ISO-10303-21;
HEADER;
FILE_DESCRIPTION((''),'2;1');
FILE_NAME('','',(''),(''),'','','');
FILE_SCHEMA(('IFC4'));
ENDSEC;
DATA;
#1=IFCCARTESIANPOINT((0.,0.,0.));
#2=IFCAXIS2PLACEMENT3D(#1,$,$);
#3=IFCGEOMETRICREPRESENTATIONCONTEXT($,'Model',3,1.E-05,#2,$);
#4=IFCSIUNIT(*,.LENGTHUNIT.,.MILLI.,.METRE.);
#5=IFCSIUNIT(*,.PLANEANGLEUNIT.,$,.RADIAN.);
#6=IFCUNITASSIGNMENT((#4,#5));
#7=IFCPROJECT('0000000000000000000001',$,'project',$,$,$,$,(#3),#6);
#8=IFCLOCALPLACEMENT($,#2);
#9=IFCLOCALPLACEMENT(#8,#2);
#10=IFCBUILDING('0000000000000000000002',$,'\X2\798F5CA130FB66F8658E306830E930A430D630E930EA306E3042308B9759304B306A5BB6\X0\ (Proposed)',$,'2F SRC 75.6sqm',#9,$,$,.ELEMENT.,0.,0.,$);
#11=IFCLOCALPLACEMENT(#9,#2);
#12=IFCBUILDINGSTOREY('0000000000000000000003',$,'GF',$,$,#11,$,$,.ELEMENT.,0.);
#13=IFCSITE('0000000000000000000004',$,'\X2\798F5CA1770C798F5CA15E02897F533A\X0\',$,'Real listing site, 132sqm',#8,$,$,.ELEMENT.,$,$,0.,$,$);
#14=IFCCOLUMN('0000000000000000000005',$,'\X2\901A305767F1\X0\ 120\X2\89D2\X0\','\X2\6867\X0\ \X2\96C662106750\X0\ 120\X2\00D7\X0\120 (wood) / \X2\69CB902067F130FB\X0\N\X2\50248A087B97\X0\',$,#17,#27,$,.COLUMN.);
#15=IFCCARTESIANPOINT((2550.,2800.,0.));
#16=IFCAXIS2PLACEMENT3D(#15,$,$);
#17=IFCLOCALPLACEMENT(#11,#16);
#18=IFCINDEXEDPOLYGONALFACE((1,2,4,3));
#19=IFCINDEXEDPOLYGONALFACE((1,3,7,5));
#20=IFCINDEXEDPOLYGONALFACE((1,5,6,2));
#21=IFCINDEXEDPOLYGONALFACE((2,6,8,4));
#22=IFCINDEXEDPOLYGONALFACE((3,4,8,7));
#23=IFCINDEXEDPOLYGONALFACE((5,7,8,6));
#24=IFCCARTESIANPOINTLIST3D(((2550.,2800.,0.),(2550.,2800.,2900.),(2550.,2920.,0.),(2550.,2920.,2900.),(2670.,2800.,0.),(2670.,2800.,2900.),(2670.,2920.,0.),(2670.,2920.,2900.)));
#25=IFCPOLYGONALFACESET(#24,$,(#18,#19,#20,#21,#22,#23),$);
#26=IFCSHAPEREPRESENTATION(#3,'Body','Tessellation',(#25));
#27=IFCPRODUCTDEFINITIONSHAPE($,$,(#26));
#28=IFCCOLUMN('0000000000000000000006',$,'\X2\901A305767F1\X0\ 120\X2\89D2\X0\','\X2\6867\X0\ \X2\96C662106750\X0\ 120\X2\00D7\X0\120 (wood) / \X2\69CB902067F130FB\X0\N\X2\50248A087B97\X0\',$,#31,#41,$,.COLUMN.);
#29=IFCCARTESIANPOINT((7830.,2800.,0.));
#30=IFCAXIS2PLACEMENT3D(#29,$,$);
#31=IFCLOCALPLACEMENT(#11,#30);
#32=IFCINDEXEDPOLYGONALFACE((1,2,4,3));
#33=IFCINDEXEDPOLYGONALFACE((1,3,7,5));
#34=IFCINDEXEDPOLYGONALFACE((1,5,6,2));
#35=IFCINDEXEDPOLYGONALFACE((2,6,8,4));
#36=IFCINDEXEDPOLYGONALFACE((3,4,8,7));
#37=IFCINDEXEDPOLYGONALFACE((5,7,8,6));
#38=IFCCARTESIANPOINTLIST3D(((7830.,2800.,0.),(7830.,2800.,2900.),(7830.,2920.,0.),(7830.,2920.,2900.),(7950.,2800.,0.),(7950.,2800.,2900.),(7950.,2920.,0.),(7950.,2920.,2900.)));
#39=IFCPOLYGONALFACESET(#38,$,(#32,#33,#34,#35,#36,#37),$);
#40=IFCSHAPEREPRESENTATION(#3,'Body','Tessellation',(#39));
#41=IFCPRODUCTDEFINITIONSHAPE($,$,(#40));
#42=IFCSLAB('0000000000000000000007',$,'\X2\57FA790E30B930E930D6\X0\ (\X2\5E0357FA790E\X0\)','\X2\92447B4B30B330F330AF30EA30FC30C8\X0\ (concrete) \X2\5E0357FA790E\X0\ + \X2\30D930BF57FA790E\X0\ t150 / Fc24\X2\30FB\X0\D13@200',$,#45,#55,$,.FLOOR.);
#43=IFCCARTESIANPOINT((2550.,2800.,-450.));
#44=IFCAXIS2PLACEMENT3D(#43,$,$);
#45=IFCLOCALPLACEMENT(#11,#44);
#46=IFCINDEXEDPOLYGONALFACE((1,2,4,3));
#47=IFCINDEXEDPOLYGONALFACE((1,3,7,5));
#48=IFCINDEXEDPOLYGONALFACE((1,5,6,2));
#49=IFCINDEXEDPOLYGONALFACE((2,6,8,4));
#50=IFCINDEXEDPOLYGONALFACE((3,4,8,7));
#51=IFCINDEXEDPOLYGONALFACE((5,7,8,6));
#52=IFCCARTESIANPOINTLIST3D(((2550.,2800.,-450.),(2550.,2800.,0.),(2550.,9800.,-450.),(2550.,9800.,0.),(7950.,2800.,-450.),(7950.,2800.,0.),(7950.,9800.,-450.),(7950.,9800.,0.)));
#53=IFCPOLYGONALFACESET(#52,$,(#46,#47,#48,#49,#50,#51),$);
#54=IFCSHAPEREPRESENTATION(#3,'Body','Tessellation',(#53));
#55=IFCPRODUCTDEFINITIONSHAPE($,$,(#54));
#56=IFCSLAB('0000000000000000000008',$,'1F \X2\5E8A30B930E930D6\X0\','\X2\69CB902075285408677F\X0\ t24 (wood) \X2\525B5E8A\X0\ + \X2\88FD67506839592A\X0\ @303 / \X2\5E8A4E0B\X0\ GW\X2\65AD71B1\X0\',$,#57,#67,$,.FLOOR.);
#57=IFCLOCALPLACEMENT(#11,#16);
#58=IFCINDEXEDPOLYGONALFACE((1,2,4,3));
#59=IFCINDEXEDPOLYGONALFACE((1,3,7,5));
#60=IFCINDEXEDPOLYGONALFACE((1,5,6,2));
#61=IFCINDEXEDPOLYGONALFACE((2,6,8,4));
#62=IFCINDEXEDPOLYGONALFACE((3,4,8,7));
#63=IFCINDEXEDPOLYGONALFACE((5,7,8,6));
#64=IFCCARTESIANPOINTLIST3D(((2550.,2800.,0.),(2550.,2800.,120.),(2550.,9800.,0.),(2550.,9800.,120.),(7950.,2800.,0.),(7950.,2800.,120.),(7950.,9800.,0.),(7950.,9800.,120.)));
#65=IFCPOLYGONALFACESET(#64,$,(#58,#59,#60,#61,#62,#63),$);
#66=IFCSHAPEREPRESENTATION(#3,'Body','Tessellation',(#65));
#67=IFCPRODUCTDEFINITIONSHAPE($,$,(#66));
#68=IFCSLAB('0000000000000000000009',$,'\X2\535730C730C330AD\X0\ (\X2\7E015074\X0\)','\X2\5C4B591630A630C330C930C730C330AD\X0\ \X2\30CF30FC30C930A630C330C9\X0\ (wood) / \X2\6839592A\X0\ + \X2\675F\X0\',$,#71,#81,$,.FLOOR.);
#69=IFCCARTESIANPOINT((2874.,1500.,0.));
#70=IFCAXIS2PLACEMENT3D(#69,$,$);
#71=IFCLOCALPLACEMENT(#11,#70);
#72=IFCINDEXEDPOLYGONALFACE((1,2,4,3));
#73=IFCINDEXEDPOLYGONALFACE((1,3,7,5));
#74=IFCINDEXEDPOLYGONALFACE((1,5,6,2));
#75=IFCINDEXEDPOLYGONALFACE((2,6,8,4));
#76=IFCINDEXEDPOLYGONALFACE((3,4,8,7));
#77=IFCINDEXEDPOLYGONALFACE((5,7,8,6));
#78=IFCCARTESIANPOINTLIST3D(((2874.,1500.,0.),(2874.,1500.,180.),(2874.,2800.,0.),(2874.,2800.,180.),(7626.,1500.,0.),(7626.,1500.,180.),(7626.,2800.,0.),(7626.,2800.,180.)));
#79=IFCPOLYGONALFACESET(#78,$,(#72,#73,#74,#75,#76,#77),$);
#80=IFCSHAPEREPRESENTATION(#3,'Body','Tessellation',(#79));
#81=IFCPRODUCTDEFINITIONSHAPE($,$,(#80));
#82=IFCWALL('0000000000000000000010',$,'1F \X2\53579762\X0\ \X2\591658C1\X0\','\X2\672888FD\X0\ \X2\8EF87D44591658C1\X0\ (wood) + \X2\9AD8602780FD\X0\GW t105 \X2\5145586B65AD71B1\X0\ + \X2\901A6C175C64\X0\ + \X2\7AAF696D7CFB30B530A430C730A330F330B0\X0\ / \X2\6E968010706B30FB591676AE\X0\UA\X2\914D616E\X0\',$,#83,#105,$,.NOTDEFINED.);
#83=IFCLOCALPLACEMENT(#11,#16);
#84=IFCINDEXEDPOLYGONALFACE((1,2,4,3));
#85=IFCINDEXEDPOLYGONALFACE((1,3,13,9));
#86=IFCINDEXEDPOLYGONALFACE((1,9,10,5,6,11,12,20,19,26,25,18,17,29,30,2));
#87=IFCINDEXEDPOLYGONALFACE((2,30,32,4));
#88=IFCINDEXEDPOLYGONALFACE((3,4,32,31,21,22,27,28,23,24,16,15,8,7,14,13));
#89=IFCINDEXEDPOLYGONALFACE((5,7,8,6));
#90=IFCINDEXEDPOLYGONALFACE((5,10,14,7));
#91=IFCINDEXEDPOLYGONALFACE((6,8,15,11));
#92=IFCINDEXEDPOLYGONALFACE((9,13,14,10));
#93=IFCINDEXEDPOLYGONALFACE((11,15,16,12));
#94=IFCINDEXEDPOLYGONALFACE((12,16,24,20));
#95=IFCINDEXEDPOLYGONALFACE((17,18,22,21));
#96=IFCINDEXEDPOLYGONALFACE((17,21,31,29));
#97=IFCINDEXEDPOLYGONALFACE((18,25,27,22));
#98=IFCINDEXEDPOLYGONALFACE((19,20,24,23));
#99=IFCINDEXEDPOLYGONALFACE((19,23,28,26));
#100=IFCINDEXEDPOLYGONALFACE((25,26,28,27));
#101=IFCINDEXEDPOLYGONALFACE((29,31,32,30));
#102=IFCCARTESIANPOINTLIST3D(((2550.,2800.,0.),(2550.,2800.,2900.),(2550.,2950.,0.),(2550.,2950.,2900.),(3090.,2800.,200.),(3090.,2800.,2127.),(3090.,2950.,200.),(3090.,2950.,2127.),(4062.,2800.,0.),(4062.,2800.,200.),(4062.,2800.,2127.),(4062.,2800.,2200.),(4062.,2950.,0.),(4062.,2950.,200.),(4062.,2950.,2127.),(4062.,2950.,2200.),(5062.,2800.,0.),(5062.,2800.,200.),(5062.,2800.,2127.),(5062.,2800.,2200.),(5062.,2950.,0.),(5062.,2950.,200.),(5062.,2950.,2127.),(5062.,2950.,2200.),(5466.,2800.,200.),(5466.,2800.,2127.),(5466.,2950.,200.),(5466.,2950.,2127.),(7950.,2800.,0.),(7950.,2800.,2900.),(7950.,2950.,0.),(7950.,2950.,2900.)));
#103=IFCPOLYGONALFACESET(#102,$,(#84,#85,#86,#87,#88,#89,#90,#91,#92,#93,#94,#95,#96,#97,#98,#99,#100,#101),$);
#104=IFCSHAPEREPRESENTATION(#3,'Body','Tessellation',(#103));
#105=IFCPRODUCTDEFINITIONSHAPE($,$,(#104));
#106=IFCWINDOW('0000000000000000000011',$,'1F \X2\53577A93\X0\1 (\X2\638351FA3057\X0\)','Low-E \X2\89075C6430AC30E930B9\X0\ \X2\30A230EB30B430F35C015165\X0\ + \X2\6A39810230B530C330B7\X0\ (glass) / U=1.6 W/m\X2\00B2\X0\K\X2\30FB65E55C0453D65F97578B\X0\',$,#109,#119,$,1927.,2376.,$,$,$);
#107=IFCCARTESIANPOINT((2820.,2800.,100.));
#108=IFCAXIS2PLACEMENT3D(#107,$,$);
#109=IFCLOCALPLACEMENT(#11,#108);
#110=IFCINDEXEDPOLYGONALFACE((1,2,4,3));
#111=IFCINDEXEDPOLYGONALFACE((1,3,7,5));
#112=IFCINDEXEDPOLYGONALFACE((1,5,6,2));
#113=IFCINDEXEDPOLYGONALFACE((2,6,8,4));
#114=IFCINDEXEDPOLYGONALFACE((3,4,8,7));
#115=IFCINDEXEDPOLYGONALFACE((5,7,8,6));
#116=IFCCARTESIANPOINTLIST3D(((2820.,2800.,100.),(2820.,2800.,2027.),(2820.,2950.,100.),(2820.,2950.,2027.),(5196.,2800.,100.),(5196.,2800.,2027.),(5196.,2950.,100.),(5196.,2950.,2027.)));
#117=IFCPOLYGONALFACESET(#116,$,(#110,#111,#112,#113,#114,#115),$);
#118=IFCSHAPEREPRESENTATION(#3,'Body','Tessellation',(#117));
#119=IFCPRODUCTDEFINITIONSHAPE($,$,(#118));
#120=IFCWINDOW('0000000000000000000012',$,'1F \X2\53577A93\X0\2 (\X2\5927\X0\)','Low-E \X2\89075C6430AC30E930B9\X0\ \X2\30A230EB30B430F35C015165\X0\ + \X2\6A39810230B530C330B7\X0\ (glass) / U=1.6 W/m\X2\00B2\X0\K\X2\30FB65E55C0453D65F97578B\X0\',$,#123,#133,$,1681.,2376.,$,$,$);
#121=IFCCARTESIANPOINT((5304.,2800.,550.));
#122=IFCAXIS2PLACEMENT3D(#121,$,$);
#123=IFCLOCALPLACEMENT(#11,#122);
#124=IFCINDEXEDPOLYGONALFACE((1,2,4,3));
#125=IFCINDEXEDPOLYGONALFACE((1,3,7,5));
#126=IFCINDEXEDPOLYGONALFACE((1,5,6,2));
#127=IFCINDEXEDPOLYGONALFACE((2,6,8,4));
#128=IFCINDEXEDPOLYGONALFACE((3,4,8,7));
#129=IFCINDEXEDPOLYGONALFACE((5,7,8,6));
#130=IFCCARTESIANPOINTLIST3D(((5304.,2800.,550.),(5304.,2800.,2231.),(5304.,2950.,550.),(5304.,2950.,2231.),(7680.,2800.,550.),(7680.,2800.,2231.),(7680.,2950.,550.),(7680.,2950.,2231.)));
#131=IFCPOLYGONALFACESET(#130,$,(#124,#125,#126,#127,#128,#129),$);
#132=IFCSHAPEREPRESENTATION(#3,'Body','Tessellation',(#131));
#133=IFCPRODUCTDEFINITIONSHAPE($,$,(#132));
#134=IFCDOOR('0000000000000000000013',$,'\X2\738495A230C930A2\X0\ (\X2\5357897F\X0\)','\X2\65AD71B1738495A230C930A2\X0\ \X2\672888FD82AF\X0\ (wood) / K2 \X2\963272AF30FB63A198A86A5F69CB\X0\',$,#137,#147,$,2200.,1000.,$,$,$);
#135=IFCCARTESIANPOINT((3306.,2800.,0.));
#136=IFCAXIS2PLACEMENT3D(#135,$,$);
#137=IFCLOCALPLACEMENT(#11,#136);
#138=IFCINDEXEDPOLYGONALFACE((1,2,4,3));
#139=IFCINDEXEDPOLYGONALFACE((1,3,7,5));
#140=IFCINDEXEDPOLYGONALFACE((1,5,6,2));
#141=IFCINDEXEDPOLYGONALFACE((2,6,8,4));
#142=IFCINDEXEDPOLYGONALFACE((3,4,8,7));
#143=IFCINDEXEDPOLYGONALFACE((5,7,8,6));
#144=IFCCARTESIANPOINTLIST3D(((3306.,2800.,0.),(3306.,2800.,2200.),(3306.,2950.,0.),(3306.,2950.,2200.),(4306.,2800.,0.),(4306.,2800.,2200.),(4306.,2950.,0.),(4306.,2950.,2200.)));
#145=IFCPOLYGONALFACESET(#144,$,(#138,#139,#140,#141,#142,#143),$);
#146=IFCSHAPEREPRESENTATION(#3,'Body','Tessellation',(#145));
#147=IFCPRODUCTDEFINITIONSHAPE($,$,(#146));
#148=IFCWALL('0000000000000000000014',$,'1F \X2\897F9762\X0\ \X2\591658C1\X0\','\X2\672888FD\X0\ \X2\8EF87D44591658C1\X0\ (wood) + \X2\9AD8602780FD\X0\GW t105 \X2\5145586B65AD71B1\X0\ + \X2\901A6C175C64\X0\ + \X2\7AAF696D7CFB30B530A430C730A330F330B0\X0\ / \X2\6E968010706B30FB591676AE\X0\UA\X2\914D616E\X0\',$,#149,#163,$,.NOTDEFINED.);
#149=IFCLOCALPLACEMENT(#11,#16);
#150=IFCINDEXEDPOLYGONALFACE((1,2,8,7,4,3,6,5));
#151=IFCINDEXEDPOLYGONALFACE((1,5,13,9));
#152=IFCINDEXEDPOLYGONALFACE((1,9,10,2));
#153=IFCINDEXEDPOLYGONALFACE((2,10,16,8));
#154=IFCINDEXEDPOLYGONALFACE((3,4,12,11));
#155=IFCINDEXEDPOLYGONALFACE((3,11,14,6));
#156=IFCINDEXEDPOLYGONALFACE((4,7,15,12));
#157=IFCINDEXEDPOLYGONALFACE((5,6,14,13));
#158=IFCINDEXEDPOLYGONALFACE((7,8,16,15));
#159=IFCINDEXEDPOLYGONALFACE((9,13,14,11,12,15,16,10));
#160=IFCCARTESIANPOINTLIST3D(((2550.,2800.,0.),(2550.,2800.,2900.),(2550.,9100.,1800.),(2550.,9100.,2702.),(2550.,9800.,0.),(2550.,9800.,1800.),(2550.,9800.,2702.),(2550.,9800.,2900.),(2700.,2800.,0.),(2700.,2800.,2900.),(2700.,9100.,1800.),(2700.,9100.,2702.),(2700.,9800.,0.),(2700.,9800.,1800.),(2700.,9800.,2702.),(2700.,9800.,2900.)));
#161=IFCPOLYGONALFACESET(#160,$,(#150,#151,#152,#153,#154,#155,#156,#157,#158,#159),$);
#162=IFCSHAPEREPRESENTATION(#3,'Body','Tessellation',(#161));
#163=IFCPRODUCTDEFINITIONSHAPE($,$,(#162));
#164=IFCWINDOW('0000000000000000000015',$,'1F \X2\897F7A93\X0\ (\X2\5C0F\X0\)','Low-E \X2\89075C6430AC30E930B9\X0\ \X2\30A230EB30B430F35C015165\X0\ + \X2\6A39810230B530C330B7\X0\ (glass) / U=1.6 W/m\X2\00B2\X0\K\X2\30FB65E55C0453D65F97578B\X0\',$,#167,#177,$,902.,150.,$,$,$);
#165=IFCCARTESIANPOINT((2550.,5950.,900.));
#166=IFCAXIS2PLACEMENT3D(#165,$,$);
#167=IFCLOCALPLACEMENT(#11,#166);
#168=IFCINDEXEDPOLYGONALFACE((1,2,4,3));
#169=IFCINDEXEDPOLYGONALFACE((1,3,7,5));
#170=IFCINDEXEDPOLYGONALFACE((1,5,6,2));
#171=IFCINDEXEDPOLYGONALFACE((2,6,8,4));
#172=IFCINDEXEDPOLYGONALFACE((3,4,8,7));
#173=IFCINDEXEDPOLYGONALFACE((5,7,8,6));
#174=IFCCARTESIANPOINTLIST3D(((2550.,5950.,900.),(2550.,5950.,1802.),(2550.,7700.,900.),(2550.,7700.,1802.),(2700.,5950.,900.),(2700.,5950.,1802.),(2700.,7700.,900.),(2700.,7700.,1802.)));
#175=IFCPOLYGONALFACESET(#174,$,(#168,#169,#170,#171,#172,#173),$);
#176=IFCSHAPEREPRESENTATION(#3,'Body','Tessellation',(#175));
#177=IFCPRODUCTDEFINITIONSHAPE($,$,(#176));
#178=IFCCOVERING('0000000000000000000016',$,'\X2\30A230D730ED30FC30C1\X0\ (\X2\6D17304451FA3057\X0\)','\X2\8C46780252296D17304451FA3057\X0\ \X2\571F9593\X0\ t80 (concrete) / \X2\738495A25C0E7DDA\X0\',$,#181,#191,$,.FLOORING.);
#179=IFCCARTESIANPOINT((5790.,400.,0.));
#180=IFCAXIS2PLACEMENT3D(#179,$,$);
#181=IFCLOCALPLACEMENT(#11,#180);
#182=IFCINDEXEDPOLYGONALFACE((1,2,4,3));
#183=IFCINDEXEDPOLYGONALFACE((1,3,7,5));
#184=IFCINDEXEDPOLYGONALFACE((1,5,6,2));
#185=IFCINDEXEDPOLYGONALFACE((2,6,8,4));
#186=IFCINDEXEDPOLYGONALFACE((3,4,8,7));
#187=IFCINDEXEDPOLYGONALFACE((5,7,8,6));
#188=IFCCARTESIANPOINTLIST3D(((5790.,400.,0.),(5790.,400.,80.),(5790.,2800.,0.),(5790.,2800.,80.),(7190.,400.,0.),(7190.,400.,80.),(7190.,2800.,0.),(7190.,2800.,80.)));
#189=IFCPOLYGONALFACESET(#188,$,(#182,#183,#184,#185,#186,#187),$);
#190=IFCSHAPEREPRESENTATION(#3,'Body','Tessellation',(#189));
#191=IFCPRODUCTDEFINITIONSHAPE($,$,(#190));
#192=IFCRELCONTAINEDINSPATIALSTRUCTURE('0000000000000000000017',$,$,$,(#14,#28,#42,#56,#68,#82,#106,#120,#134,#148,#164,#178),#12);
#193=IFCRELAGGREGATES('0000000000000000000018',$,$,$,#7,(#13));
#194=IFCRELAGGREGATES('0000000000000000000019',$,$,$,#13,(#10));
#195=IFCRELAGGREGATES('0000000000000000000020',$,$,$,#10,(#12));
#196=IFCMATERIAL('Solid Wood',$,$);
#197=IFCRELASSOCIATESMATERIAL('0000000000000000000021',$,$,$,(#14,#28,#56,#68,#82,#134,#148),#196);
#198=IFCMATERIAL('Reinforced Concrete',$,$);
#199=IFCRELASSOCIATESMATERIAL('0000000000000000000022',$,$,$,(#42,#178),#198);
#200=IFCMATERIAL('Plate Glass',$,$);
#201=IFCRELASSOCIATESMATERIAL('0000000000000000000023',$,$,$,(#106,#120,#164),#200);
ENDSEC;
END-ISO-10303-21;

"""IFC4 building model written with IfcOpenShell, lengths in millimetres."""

from ifc_helpers import new_model, si_unit, frame, frame_2d, origin, place, context, project, spatial, rectangle, extrude, material, element, fill, save


model = new_model("IFC4")

# Units and contexts
model_context = context("Model", 3, precision=1e-05, world=origin())
ifc_project = project(units=[si_unit("LENGTHUNIT", "METRE", prefix="MILLI"), si_unit("PLANEANGLEUNIT", "RADIAN")], contexts=[model_context])

# Site, building, storey
site_placement = place(None, origin())
site = spatial("IfcSite", under=ifc_project, at=site_placement, Name="福岡県福岡市西区", ObjectType="Real listing site, 132sqm", CompositionType="ELEMENT", RefElevation=0.0)
building_placement = place(site_placement, origin())
building = spatial("IfcBuilding", under=site, at=building_placement, Name="福岡・書斎とライブラリのある静かな家 (Proposed)", ObjectType="2F SRC 75.6sqm", CompositionType="ELEMENT", ElevationOfRefHeight=0.0, ElevationOfTerrain=0.0)
storey_placement = place(building_placement, origin())
storey = spatial("IfcBuildingStorey", under=building, at=storey_placement, Name="GF", CompositionType="ELEMENT", Elevation=0.0)

# Columns
ifc_material_1 = material(Name="Solid Wood")
column_1_placement = place(storey_placement, frame((2550.0, 2800.0, 0.0)))
element("IfcColumn", 1, at=column_1_placement, inside=storey, material=ifc_material_1, Name="通し柱 120角", Description="桧 集成材 120×120 (wood) / 構造柱・N値計算", PredefinedType="COLUMN", context=model_context, shape_type="SweptSolid", body=[
    extrude(rectangle(XDim=120.0, YDim=120.0, at=frame_2d((60.0, 60.0))), frame((2550.0, 2800.0, 0.0)), (0.0, 0.0, 1.0), 2900.0),
])
column_2_placement = place(storey_placement, frame((7830.0, 2800.0, 0.0)))
element("IfcColumn", 2, at=column_2_placement, inside=storey, material=ifc_material_1, Name="通し柱 120角", Description="桧 集成材 120×120 (wood) / 構造柱・N値計算", PredefinedType="COLUMN", context=model_context, shape_type="SweptSolid", body=[
    extrude(rectangle(XDim=120.0, YDim=120.0, at=frame_2d((60.0, 60.0))), frame((7830.0, 2800.0, 0.0)), (0.0, 0.0, 1.0), 2900.0),
])

# Slabs
ifc_material_2 = material(Name="Reinforced Concrete")
slab_1_placement = place(storey_placement, frame((2550.0, 2800.0, -450.0)))
element("IfcSlab", 3, at=slab_1_placement, inside=storey, material=ifc_material_2, Name="基礎スラブ (布基礎)", Description="鉄筋コンクリート (concrete) 布基礎 + ベタ基礎 t150 / Fc24・D13@200", PredefinedType="FLOOR", context=model_context, shape_type="SweptSolid", body=[
    extrude(rectangle(XDim=5400.0, YDim=7000.0, at=frame_2d((2700.0, 3500.0))), frame((2550.0, 2800.0, -450.0)), (0.0, 0.0, 1.0), 450.0),
])
slab_2_placement = place(storey_placement, frame((2550.0, 2800.0, 0.0)))
element("IfcSlab", 4, at=slab_2_placement, inside=storey, material=ifc_material_1, Name="1F 床スラブ", Description="構造用合板 t24 (wood) 剛床 + 製材根太 @303 / 床下 GW断熱", PredefinedType="FLOOR", context=model_context, shape_type="SweptSolid", body=[
    extrude(rectangle(XDim=5400.0, YDim=7000.0, at=frame_2d((2700.0, 3500.0))), frame((2550.0, 2800.0, 0.0)), (0.0, 0.0, 1.0), 120.0),
])
slab_3_placement = place(storey_placement, frame((2874.0, 1500.0, 0.0)))
element("IfcSlab", 5, at=slab_3_placement, inside=storey, material=ifc_material_1, Name="南デッキ (縁側)", Description="屋外ウッドデッキ ハードウッド (wood) / 根太 + 束", PredefinedType="FLOOR", context=model_context, shape_type="SweptSolid", body=[
    extrude(rectangle(XDim=4752.0, YDim=1300.0, at=frame_2d((2376.0, 650.0))), frame((2874.0, 1500.0, 0.0)), (0.0, 0.0, 1.0), 180.0),
])

# Wall, openings, windows, door
wall_1_placement = place(storey_placement, frame((2550.0, 2800.0, 0.0)))
wall_1 = element("IfcWall", 6, at=wall_1_placement, inside=storey, material=ifc_material_1, Name="1F 南面 外壁", Description="木製 軸組外壁 (wood) + 高性能GW t105 充填断熱 + 通気層 + 窯業系サイディング / 準耐火・外皮UA配慮", PredefinedType="NOTDEFINED", context=model_context, shape_type="SweptSolid", body=[
    extrude(rectangle(XDim=5400.0, YDim=150.0, at=frame_2d((2700.0, 75.0))), frame((2550.0, 2800.0, 0.0)), (0.0, 0.0, 1.0), 2900.0),
])
opening_1_placement = place(storey_placement, frame((2820.0, 2800.0, 100.0)))
opening_1 = element("IfcOpeningElement", 7, at=opening_1_placement, cuts=wall_1, PredefinedType="NOTDEFINED", context=model_context, shape_type="SweptSolid", body=[
    extrude(rectangle(XDim=2376.0, YDim=150.0, at=frame_2d((1188.0, 75.0))), frame((2820.0, 2800.0, 100.0)), (0.0, 0.0, 1.0), 1927.0),
])
opening_2_placement = place(storey_placement, frame((5304.0, 2800.0, 550.0)))
opening_2 = element("IfcOpeningElement", 8, at=opening_2_placement, cuts=wall_1, PredefinedType="NOTDEFINED", context=model_context, shape_type="SweptSolid", body=[
    extrude(rectangle(XDim=2376.0, YDim=150.0, at=frame_2d((1188.0, 75.0))), frame((5304.0, 2800.0, 550.0)), (0.0, 0.0, 1.0), 1681.0),
])
opening_3_placement = place(storey_placement, frame((3306.0, 2800.0, 0.0)))
opening_3 = element("IfcOpeningElement", 9, at=opening_3_placement, cuts=wall_1, PredefinedType="NOTDEFINED", context=model_context, shape_type="SweptSolid", body=[
    extrude(rectangle(XDim=1000.0, YDim=150.0, at=frame_2d((500.0, 75.0))), frame((3306.0, 2800.0, 0.0)), (0.0, 0.0, 1.0), 2200.0),
])
ifc_material_3 = material(Name="Plate Glass")
window_1_placement = place(storey_placement, frame((2820.0, 2800.0, 100.0)))
window_1 = element("IfcWindow", 10, at=window_1_placement, inside=storey, material=ifc_material_3, Name="1F 南窓1 (掃出し)", Description="Low-E 複層ガラス アルゴン封入 + 樹脂サッシ (glass) / U=1.6 W/m²K・日射取得型", OverallHeight=1927.0, OverallWidth=2376.0, context=model_context, shape_type="SweptSolid", body=[
    extrude(rectangle(XDim=2376.0, YDim=150.0, at=frame_2d((1188.0, 75.0))), frame((2820.0, 2800.0, 100.0)), (0.0, 0.0, 1.0), 1927.0),
])
fill(opening_1, window_1)
window_2_placement = place(storey_placement, frame((5304.0, 2800.0, 550.0)))
window_2 = element("IfcWindow", 11, at=window_2_placement, inside=storey, material=ifc_material_3, Name="1F 南窓2 (大)", Description="Low-E 複層ガラス アルゴン封入 + 樹脂サッシ (glass) / U=1.6 W/m²K・日射取得型", OverallHeight=1681.0, OverallWidth=2376.0, context=model_context, shape_type="SweptSolid", body=[
    extrude(rectangle(XDim=2376.0, YDim=150.0, at=frame_2d((1188.0, 75.0))), frame((5304.0, 2800.0, 550.0)), (0.0, 0.0, 1.0), 1681.0),
])
fill(opening_2, window_2)
door_placement = place(storey_placement, frame((3306.0, 2800.0, 0.0)))
door = element("IfcDoor", 12, at=door_placement, inside=storey, material=ifc_material_1, Name="玄関ドア (南西)", Description="断熱玄関ドア 木製芯 (wood) / K2 防犯・採風機構", OverallHeight=2200.0, OverallWidth=1000.0, context=model_context, shape_type="SweptSolid", body=[
    extrude(rectangle(XDim=1000.0, YDim=150.0, at=frame_2d((500.0, 75.0))), frame((3306.0, 2800.0, 0.0)), (0.0, 0.0, 1.0), 2200.0),
])
fill(opening_3, door)

# Wall, opening, window
wall_2_placement = place(storey_placement, frame((2550.0, 2800.0, 0.0)))
wall_2 = element("IfcWall", 13, at=wall_2_placement, inside=storey, material=ifc_material_1, Name="1F 西面 外壁", Description="木製 軸組外壁 (wood) + 高性能GW t105 充填断熱 + 通気層 + 窯業系サイディング / 準耐火・外皮UA配慮", PredefinedType="NOTDEFINED", context=model_context, shape_type="SweptSolid", body=[
    extrude(rectangle(XDim=150.0, YDim=7000.0, at=frame_2d((75.0, 3500.0))), frame((2550.0, 2800.0, 0.0)), (0.0, 0.0, 1.0), 2900.0),
])
opening_4_placement = place(storey_placement, frame((2550.0, 5950.0, 900.0)))
opening_4 = element("IfcOpeningElement", 14, at=opening_4_placement, cuts=wall_2, PredefinedType="NOTDEFINED", context=model_context, shape_type="SweptSolid", body=[
    extrude(rectangle(XDim=150.0, YDim=1750.0, at=frame_2d((75.0, 875.0))), frame((2550.0, 5950.0, 900.0)), (0.0, 0.0, 1.0), 902.0),
])
window_3_placement = place(storey_placement, frame((2550.0, 5950.0, 900.0)))
window_3 = element("IfcWindow", 15, at=window_3_placement, inside=storey, material=ifc_material_3, Name="1F 西窓 (小)", Description="Low-E 複層ガラス アルゴン封入 + 樹脂サッシ (glass) / U=1.6 W/m²K・日射取得型", OverallHeight=902.0, OverallWidth=150.0, context=model_context, shape_type="SweptSolid", body=[
    extrude(rectangle(XDim=150.0, YDim=1750.0, at=frame_2d((75.0, 875.0))), frame((2550.0, 5950.0, 900.0)), (0.0, 0.0, 1.0), 902.0),
])
fill(opening_4, window_3)

# Covering
covering_1_placement = place(storey_placement, frame((5790.0, 400.0, 0.0)))
element("IfcCovering", 16, at=covering_1_placement, inside=storey, material=ifc_material_2, Name="アプローチ (洗い出し)", Description="豆砂利洗い出し 土間 t80 (concrete) / 玄関導線", PredefinedType="FLOORING", context=model_context, shape_type="SweptSolid", body=[
    extrude(rectangle(XDim=1400.0, YDim=2400.0, at=frame_2d((700.0, 1200.0))), frame((5790.0, 400.0, 0.0)), (0.0, 0.0, 1.0), 80.0),
])

save(model, "model.ifc")
